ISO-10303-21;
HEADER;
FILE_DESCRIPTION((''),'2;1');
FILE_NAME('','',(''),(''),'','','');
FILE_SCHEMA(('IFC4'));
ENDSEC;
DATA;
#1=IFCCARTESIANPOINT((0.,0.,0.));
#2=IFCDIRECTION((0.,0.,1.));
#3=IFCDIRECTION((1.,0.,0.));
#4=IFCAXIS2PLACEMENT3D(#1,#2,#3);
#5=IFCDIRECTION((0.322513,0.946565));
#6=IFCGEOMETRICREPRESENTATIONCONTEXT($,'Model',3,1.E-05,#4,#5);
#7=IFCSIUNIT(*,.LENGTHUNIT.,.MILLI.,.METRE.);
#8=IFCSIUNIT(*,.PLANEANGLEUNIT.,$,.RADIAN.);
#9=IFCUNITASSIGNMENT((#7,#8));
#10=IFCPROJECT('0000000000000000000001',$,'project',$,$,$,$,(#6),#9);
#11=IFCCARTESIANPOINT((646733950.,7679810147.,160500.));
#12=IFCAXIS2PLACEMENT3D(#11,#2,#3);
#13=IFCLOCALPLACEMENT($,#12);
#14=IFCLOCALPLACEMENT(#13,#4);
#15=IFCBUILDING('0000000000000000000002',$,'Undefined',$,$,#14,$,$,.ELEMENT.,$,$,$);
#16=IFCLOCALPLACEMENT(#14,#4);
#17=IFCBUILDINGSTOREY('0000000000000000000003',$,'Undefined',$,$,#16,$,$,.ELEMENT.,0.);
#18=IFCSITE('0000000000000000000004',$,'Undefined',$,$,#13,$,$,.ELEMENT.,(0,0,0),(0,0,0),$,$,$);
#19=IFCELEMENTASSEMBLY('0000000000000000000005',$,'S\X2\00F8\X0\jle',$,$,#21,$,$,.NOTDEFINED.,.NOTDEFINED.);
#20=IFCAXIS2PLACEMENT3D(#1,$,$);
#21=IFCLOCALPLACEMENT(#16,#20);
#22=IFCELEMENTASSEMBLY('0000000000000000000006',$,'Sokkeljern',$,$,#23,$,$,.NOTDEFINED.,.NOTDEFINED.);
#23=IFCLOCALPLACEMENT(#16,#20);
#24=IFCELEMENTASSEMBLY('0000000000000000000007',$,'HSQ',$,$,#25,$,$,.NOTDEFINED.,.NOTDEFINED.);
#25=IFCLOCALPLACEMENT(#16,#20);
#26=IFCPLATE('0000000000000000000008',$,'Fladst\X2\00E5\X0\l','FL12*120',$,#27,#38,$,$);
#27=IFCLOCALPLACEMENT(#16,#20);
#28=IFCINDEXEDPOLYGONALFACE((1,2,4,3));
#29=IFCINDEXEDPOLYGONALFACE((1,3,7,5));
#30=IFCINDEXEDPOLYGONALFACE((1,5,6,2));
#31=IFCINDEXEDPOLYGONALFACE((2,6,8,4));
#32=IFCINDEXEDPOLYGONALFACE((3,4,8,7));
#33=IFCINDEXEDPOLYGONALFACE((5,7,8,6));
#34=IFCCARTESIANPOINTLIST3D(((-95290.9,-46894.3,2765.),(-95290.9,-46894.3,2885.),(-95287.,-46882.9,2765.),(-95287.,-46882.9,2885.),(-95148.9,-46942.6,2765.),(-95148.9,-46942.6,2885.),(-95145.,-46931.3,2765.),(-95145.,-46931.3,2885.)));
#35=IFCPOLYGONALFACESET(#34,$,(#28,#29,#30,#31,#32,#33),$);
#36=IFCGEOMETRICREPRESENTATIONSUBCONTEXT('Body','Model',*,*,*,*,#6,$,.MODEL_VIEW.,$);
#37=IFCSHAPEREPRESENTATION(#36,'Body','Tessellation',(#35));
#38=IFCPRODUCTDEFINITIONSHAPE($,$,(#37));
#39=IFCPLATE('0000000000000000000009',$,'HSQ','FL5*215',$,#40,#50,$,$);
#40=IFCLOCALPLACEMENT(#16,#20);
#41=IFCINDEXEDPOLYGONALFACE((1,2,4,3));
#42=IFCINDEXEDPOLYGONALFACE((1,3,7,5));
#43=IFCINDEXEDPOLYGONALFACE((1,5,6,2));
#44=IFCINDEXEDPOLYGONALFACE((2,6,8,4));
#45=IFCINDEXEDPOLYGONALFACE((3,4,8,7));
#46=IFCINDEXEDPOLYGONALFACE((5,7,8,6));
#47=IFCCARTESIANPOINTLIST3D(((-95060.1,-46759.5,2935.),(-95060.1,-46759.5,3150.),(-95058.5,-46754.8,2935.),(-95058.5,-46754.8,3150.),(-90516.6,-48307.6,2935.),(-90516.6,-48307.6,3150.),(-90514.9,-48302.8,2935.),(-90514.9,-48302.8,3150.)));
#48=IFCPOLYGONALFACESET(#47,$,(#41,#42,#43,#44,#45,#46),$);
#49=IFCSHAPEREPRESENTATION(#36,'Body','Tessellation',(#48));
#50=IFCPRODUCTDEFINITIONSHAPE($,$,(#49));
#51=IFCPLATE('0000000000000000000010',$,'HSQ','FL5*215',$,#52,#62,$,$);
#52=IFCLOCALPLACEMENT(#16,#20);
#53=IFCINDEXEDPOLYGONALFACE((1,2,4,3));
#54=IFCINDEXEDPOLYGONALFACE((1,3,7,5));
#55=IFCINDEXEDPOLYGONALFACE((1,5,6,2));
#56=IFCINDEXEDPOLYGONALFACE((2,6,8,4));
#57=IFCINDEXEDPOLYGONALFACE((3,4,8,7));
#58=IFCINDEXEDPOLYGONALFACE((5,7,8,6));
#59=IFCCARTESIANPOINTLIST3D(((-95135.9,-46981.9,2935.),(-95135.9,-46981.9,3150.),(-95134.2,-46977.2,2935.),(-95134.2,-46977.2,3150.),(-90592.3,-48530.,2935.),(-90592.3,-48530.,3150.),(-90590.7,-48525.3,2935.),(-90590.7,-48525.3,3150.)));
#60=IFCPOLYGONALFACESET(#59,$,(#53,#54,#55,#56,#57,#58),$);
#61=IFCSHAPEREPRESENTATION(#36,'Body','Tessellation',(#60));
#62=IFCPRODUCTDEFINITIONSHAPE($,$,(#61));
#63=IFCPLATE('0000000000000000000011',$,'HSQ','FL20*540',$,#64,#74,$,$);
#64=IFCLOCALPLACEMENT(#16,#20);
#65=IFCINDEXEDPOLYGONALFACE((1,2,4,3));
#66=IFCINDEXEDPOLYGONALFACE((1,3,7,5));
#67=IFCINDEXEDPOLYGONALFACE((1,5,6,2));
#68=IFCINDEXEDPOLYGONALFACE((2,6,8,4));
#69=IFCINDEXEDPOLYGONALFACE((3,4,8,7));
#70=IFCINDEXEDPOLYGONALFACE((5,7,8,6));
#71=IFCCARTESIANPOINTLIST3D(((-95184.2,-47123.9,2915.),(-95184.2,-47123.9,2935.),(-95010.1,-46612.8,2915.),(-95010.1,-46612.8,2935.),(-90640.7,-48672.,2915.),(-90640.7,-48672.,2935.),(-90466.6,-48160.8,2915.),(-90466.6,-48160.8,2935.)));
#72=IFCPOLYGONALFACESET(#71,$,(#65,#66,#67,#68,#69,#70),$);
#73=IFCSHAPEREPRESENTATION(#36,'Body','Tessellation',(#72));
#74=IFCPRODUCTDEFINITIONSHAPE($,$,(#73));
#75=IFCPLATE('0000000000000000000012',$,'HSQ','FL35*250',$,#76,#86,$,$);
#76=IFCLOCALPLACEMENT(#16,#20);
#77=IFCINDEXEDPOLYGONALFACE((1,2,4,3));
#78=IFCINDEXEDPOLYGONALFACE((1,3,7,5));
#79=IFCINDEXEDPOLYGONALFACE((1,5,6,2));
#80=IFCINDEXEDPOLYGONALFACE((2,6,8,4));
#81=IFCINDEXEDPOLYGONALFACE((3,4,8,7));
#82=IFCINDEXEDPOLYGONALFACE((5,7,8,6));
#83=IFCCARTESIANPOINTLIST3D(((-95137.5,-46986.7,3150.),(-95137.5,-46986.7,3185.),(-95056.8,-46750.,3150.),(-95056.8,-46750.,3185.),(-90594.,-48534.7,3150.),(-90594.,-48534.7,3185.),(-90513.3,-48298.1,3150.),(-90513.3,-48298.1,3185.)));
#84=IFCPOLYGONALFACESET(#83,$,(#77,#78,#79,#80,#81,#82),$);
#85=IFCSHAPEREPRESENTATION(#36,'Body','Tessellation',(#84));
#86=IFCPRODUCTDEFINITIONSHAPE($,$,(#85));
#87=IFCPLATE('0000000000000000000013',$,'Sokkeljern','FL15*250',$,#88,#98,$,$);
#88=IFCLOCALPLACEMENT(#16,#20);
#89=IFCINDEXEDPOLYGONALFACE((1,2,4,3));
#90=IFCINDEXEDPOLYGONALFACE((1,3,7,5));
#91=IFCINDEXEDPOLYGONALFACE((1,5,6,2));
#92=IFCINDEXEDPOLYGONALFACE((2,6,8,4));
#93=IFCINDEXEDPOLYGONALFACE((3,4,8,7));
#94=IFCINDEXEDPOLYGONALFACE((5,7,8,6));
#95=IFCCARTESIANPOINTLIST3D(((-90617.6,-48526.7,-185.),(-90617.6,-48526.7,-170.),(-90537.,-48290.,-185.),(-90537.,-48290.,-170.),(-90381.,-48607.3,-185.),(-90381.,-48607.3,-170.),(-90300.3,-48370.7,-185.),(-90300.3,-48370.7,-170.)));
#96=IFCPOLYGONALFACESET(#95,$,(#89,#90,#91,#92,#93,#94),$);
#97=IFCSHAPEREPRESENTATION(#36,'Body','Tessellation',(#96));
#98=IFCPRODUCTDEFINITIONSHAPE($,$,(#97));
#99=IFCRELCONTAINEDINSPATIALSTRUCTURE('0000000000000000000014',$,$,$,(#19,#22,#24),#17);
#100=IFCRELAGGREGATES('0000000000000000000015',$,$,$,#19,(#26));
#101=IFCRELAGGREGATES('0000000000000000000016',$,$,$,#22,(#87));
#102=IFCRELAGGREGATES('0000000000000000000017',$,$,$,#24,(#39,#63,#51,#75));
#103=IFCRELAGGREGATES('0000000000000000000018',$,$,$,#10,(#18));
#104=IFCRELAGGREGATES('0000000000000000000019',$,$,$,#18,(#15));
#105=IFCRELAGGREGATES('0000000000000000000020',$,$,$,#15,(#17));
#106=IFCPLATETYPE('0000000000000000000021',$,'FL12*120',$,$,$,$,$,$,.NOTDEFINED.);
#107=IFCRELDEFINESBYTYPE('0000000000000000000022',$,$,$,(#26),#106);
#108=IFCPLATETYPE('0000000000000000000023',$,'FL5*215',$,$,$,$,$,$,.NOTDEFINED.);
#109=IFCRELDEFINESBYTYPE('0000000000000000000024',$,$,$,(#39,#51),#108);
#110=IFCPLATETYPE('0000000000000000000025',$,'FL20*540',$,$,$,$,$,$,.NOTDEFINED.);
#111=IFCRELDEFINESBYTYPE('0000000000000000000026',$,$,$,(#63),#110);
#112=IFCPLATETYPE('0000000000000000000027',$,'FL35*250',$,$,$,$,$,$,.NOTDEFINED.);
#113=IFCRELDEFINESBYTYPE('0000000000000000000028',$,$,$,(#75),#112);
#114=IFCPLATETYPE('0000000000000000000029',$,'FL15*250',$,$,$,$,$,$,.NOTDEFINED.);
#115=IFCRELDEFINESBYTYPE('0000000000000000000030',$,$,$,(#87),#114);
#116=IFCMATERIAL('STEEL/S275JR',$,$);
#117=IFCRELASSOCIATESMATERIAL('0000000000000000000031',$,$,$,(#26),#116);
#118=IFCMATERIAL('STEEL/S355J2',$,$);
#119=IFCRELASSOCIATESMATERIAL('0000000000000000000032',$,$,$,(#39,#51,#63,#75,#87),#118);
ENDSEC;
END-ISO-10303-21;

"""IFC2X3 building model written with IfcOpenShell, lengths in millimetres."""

from ifc_helpers import new_model, si_unit, direction, frame, origin_with_axes, place, context, subcontext, project, spatial, polyline, outline, extrude, material, type_object, element, aggregate, save


model = new_model("IFC2X3")

# Units and contexts
model_context = context("Model", 3, precision=1e-05, world=origin_with_axes(), true_north=direction((0.322513, 0.946565)))
body_context = subcontext(model_context, "Body", "Model", "MODEL_VIEW")
ifc_project = project(units=[si_unit("LENGTHUNIT", "METRE", prefix="MILLI"), si_unit("PLANEANGLEUNIT", "RADIAN")], contexts=[model_context])

# Site, building, storey
site_placement = place(None, frame((646733950.0, 7679810147.0, 160500.0), z_axis=(0.0, 0.0, 1.0), x_axis=(1.0, 0.0, 0.0)))
site = spatial("IfcSite", under=ifc_project, at=site_placement, Name="Undefined", CompositionType="ELEMENT", RefLatitude=(0, 0, 0), RefLongitude=(0, 0, 0))
building_placement = place(site_placement, origin_with_axes())
building = spatial("IfcBuilding", under=site, at=building_placement, Name="Undefined", CompositionType="ELEMENT")
storey_placement = place(building_placement, origin_with_axes())
storey = spatial("IfcBuildingStorey", under=building, at=storey_placement, Name="Undefined", CompositionType="ELEMENT", Elevation=0.0)

# Element assembly
assembly_1_placement = place(storey_placement, origin_with_axes())
assembly_1 = element("IfcElementAssembly", 1, at=assembly_1_placement, inside=storey, Name="Søjle", AssemblyPlace="NOTDEFINED", PredefinedType="NOTDEFINED")

# Shared definitions
ifc_material_1 = material(Name="STEEL/S275JR")

# Element assembly
assembly_2_placement = place(storey_placement, origin_with_axes())
assembly_2 = element("IfcElementAssembly", 2, at=assembly_2_placement, inside=storey, Name="Sokkeljern", AssemblyPlace="NOTDEFINED", PredefinedType="NOTDEFINED")
ifc_material_2 = material(Name="STEEL/S355J2")

# Element assembly
assembly_3_placement = place(storey_placement, origin_with_axes())
assembly_3 = element("IfcElementAssembly", 3, at=assembly_3_placement, inside=storey, Name="HSQ", AssemblyPlace="NOTDEFINED", PredefinedType="NOTDEFINED")

# Plates
plate_type_1 = type_object("IfcPlateType", Name="FL12*120", PredefinedType="NOTDEFINED")
plate_1_placement = place(assembly_1_placement, frame((-95146.9, -46937.0, 2885.0), z_axis=(-0.322513, -0.946565, 0.0), x_axis=(-0.946565, 0.322513, 0.0)))
plate_1 = element("IfcPlate", 4, at=plate_1_placement, type_object=plate_type_1, material=ifc_material_1, Name="Fladstål", Description="FL12*120", context=body_context, shape_type="SweptSolid", body=[
    extrude(outline(polyline([(0.0, 0.0), (150.0, 0.0), (150.0, 120.0), (0.0, 120.0), (0.0, 0.0)])), frame((0.0, 0.0, -6.0), z_axis=(0.0, 0.0, 1.0), x_axis=(1.0, 0.0, 0.0)), (0.0, 0.0, 1.0), 12.0),
])
aggregate(assembly_1, [plate_1])
plate_type_2 = type_object("IfcPlateType", Name="FL5*215", PredefinedType="NOTDEFINED")
plate_2_placement = place(assembly_3_placement, frame((-95059.3, -46757.1, 3042.5), z_axis=(-0.322513, -0.946565, 0.0), x_axis=(0.946565, -0.322513, 0.0)))
plate_2 = element("IfcPlate", 5, at=plate_2_placement, type_object=plate_type_2, material=ifc_material_2, Name="HSQ", Description="FL5*215", context=body_context, shape_type="SweptSolid", body=[
    extrude(outline(polyline([(0.0, -107.5), (0.0, 107.5), (4800.0, 107.5), (4800.0, -107.5), (0.0, -107.5)])), frame((0.0, 0.0, -2.5), z_axis=(0.0, 0.0, 1.0), x_axis=(1.0, 0.0, 0.0)), (0.0, 0.0, 1.0), 5.0),
])
plate_3_placement = place(assembly_3_placement, frame((-95135.0, -46979.6, 3042.5), z_axis=(-0.322513, -0.946565, 0.0), x_axis=(0.946565, -0.322513, 0.0)))
plate_3 = element("IfcPlate", 6, at=plate_3_placement, type_object=plate_type_2, material=ifc_material_2, Name="HSQ", Description="FL5*215", context=body_context, shape_type="SweptSolid", body=[
    extrude(outline(polyline([(0.0, -107.5), (0.0, 107.5), (4800.0, 107.5), (4800.0, -107.5), (0.0, -107.5)])), frame((0.0, 0.0, -2.5), z_axis=(0.0, 0.0, 1.0), x_axis=(1.0, 0.0, 0.0)), (0.0, 0.0, 1.0), 5.0),
])
plate_type_3 = type_object("IfcPlateType", Name="FL20*540", PredefinedType="NOTDEFINED")
plate_4_placement = place(assembly_3_placement, frame((-95097.2, -46868.3, 2925.0), z_axis=(0.0, 0.0, 1.0), x_axis=(0.946565, -0.322513, 0.0)))
plate_4 = element("IfcPlate", 7, at=plate_4_placement, type_object=plate_type_3, material=ifc_material_2, Name="HSQ", Description="FL20*540", context=body_context, shape_type="SweptSolid", body=[
    extrude(outline(polyline([(0.0, -270.0), (0.0, 270.0), (4800.0, 270.0), (4800.0, -270.0), (0.0, -270.0)])), frame((0.0, 0.0, -10.0), z_axis=(0.0, 0.0, 1.0), x_axis=(1.0, 0.0, 0.0)), (0.0, 0.0, 1.0), 20.0),
])
plate_type_4 = type_object("IfcPlateType", Name="FL35*250", PredefinedType="NOTDEFINED")
plate_5_placement = place(assembly_3_placement, frame((-95097.2, -46868.3, 3167.5), z_axis=(0.0, 0.0, 1.0), x_axis=(0.946565, -0.322513, 0.0)))
plate_5 = element("IfcPlate", 8, at=plate_5_placement, type_object=plate_type_4, material=ifc_material_2, Name="HSQ", Description="FL35*250", context=body_context, shape_type="SweptSolid", body=[
    extrude(outline(polyline([(0.0, -125.0), (0.0, 125.0), (4800.0, 125.0), (4800.0, -125.0), (0.0, -125.0)])), frame((0.0, 0.0, -17.5), z_axis=(0.0, 0.0, 1.0), x_axis=(1.0, 0.0, 0.0)), (0.0, 0.0, 1.0), 35.0),
])
plate_type_5 = type_object("IfcPlateType", Name="FL15*250", PredefinedType="NOTDEFINED")
plate_6_placement = place(assembly_2_placement, frame((-90537.0, -48290.0, -177.5), z_axis=(0.0, 0.0, 1.0), x_axis=(-0.322513, -0.946565, 0.0)))
plate_6 = element("IfcPlate", 9, at=plate_6_placement, type_object=plate_type_5, material=ifc_material_2, Name="Sokkeljern", Description="FL15*250", context=body_context, shape_type="SweptSolid", body=[
    extrude(outline(polyline([(0.0, 0.0), (250.0, 0.0), (250.0, 250.0), (0.0, 250.0), (0.0, 0.0)])), frame((0.0, 0.0, -7.5), z_axis=(0.0, 0.0, 1.0), x_axis=(1.0, 0.0, 0.0)), (0.0, 0.0, 1.0), 15.0),
])
aggregate(assembly_2, [plate_6])

aggregate(assembly_3, [plate_2, plate_4, plate_3, plate_5])

save(model, "model.ifc")
